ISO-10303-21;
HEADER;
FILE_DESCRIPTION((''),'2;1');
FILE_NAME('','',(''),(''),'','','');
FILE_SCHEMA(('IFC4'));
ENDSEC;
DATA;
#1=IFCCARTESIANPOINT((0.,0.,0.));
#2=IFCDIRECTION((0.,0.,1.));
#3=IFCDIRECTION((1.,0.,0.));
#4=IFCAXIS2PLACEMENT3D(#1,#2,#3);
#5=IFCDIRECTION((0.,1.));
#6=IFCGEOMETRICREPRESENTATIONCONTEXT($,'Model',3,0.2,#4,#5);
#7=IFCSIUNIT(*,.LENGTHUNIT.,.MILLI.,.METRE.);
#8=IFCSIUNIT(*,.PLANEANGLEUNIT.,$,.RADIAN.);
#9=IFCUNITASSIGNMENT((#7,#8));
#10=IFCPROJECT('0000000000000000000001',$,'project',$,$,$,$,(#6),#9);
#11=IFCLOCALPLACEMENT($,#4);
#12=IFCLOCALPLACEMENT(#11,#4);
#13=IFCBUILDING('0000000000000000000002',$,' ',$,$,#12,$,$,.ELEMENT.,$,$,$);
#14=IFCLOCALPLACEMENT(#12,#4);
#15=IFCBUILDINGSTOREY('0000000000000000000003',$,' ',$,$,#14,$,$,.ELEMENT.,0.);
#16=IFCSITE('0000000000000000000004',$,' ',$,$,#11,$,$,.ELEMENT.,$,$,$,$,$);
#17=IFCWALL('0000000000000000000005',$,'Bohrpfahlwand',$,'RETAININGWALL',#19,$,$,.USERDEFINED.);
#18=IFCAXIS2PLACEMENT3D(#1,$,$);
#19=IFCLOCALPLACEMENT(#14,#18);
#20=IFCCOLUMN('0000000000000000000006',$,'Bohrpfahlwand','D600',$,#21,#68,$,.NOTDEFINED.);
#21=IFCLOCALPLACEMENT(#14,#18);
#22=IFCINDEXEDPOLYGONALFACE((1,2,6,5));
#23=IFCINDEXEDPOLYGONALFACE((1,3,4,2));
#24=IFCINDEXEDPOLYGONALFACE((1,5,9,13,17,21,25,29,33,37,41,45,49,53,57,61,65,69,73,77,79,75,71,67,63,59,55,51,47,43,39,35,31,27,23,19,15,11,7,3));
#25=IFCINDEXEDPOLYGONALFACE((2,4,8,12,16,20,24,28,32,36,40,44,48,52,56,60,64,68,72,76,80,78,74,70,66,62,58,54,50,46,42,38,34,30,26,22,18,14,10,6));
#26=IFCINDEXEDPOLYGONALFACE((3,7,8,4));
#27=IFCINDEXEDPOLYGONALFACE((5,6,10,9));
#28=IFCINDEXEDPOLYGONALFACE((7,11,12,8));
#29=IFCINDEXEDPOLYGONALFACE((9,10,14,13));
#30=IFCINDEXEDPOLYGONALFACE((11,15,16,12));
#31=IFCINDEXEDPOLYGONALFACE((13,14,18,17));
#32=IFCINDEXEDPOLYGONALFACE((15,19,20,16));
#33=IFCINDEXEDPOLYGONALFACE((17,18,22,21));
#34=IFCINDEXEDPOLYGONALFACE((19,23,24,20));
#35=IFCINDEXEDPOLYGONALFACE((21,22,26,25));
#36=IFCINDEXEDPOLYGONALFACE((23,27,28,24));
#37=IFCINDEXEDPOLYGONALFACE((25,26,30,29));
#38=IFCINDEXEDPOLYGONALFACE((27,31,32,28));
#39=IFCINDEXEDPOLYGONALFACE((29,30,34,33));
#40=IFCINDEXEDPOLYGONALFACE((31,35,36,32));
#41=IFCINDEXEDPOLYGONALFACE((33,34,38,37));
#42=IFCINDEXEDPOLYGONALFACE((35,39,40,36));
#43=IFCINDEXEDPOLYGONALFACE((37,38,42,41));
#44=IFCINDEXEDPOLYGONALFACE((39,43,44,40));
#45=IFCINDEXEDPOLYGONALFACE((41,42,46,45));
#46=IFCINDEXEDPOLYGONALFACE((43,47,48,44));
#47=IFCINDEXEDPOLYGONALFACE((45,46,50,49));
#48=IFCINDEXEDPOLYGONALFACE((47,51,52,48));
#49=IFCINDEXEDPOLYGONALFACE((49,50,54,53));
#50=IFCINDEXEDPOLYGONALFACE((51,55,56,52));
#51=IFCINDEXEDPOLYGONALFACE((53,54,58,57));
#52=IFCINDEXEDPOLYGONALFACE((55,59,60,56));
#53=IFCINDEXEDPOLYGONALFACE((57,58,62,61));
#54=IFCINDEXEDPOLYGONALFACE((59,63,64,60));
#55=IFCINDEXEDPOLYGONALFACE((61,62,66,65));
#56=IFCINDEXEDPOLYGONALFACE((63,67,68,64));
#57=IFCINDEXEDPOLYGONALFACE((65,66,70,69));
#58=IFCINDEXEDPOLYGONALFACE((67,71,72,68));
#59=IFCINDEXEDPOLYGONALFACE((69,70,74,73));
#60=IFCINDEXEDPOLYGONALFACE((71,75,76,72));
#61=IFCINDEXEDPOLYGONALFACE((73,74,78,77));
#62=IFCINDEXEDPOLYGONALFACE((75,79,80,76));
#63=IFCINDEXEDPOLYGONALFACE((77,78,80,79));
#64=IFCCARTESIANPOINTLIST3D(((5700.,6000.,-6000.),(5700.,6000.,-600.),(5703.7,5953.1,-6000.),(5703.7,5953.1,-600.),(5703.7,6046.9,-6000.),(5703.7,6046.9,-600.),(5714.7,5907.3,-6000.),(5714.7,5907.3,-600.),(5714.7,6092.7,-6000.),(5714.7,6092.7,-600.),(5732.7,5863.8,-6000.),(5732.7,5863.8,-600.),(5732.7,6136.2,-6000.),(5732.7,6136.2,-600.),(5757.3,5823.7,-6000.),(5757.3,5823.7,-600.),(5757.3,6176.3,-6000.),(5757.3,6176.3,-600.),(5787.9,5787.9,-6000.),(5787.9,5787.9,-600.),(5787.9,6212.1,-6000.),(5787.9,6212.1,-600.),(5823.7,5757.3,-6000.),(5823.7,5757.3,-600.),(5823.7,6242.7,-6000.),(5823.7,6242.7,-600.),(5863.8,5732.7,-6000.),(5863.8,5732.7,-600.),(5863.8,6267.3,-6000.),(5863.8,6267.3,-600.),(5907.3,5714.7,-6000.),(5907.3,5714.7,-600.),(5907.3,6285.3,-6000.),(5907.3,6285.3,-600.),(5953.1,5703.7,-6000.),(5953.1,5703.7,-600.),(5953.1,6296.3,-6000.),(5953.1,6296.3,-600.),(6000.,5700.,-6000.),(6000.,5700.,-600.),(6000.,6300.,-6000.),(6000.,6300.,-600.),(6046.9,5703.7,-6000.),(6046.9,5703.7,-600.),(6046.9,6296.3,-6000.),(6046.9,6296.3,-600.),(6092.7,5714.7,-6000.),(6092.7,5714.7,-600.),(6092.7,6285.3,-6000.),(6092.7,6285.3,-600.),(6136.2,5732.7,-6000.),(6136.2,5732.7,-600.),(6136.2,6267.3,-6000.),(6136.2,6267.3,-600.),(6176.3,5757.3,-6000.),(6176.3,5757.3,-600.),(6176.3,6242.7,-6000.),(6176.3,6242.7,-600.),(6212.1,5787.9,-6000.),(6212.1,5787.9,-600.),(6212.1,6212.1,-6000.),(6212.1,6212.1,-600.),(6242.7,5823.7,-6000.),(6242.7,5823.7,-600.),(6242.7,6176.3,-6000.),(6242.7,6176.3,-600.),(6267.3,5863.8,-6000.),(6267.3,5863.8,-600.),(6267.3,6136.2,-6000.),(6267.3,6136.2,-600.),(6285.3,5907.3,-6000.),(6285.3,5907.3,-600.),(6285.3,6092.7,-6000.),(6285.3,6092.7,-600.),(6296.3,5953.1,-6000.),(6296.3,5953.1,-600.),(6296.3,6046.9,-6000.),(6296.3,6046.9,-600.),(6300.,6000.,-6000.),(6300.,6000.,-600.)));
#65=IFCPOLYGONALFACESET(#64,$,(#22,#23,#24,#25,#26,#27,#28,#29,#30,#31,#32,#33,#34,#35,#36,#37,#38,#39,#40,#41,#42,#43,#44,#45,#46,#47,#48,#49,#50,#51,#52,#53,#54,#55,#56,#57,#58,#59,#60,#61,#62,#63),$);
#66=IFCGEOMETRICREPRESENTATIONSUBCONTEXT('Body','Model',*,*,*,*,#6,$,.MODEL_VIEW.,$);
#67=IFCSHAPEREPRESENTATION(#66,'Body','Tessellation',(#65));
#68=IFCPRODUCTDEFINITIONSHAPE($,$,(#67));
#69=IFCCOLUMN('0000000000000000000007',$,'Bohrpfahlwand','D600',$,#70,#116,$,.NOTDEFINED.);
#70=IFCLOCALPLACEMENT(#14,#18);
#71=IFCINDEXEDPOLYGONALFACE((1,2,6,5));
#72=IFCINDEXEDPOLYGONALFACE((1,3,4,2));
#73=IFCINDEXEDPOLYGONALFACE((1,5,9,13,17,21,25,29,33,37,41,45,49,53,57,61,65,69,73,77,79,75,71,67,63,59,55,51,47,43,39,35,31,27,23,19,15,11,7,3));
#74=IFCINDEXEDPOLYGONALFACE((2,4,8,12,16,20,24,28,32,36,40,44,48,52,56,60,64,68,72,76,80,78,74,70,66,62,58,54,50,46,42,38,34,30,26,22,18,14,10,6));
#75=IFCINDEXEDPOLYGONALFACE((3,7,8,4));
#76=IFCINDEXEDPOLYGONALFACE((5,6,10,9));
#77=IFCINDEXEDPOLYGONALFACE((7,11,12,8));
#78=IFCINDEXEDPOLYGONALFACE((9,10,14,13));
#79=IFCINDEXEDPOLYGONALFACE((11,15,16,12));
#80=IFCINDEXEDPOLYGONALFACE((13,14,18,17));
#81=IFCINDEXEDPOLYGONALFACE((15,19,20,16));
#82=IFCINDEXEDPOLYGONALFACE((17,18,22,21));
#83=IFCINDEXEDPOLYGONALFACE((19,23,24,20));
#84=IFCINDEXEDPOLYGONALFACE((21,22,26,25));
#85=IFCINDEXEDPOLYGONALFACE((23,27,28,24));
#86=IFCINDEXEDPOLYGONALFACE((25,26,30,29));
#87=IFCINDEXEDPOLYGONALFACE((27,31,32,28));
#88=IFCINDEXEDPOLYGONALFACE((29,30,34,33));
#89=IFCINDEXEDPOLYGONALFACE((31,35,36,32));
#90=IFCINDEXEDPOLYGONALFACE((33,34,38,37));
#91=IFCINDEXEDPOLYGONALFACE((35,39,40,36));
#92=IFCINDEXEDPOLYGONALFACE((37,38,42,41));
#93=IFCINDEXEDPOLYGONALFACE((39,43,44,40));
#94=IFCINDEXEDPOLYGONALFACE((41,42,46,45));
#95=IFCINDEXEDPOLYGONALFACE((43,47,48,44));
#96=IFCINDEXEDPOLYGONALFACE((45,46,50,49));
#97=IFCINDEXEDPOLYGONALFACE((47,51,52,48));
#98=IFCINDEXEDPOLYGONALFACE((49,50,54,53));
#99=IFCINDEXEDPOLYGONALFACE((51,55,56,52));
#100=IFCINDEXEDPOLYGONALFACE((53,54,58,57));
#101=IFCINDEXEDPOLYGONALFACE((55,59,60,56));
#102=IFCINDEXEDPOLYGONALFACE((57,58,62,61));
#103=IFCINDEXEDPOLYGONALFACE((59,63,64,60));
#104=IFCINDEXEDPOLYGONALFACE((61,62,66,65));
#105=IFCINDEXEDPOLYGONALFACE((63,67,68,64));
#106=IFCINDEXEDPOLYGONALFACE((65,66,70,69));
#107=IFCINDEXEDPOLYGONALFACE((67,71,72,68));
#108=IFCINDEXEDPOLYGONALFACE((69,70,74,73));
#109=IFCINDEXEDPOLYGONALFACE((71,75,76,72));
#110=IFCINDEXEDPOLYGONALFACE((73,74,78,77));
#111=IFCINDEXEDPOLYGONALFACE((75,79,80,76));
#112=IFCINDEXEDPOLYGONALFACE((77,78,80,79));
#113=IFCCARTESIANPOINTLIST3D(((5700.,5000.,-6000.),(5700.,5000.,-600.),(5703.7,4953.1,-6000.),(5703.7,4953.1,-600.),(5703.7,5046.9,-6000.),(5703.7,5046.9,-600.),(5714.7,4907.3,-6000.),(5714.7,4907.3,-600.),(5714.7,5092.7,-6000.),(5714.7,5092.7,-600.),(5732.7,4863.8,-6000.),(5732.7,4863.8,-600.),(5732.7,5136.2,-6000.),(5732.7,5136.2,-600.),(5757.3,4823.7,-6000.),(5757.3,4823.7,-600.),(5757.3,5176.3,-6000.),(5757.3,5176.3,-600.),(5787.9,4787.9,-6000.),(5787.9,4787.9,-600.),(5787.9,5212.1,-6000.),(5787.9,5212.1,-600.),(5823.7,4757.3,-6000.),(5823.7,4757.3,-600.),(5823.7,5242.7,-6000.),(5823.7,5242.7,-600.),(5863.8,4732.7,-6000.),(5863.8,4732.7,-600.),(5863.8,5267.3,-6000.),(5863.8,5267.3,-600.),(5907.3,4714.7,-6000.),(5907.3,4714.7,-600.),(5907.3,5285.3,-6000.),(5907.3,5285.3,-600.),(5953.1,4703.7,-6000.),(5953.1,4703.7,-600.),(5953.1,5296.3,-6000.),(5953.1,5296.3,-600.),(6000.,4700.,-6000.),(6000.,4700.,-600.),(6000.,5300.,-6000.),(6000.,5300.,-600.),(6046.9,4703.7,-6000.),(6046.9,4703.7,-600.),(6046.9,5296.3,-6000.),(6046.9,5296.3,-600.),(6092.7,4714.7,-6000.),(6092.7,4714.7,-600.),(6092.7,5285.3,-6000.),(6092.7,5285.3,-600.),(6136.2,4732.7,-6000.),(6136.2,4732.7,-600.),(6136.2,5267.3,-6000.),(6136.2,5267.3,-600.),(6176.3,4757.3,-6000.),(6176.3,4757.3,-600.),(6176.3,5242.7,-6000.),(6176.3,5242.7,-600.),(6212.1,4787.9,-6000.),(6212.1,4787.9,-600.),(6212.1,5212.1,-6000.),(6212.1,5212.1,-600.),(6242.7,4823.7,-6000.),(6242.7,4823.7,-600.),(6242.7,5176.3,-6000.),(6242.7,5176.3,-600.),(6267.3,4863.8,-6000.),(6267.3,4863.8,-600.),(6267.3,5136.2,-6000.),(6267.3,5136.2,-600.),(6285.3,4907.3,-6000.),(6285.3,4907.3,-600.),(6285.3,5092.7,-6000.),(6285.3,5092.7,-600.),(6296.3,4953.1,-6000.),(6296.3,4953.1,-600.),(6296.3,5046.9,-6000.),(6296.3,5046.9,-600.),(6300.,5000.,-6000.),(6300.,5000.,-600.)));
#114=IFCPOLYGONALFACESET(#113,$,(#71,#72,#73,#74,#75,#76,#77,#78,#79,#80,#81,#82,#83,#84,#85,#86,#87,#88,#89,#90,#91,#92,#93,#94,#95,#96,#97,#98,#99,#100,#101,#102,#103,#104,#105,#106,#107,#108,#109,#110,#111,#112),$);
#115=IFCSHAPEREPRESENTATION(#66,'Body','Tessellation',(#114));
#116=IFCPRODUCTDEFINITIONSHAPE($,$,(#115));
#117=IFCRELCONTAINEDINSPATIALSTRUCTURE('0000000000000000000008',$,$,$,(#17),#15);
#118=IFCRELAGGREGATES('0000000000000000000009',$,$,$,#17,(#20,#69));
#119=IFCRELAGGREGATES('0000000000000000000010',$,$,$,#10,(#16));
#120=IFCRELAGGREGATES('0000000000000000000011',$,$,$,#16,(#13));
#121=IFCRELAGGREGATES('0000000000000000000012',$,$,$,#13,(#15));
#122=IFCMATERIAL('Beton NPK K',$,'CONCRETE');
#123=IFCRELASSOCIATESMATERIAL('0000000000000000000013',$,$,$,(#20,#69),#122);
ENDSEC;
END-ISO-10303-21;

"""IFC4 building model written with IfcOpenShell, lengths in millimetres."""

from ifc_helpers import new_model, si_unit, direction, frame, origin_with_axes, place, context, subcontext, project, spatial, line, indexed_curve, outline, extrude, material, element, aggregate, save


model = new_model("IFC4")

# Units and contexts
model_context = context("Model", 3, precision=0.2, world=origin_with_axes(), true_north=direction((0.0, 1.0)))
body_context = subcontext(model_context, "Body", "Model", "MODEL_VIEW")
ifc_project = project(units=[si_unit("LENGTHUNIT", "METRE", prefix="MILLI"), si_unit("PLANEANGLEUNIT", "RADIAN")], contexts=[model_context])

# Site, building, storey
site_placement = place(None, origin_with_axes())
site = spatial("IfcSite", under=ifc_project, at=site_placement, Name=" ", CompositionType="ELEMENT")
building_placement = place(site_placement, origin_with_axes())
building = spatial("IfcBuilding", under=site, at=building_placement, Name=" ", CompositionType="ELEMENT")
storey_placement = place(building_placement, origin_with_axes())
storey = spatial("IfcBuildingStorey", under=building, at=storey_placement, Name=" ", CompositionType="ELEMENT", Elevation=0.0)

# Wall, columns
wall_1_placement = place(storey_placement, frame((6000.0, 5000.0, -6000.0), z_axis=(-1.0, 0.0, 0.0), x_axis=(0.0, 0.0, 1.0)))
wall_1 = element("IfcWall", 1, at=wall_1_placement, inside=storey, Name="Bohrpfahlwand", ObjectType="RETAININGWALL", PredefinedType="USERDEFINED")
ifc_material_1 = material(Name="Beton NPK K", Category="CONCRETE")
column_1_placement = place(wall_1_placement, frame((0.0, 1000.0, 0.0), z_axis=(0.0, 0.0, 1.0), x_axis=(1.0, 0.0, 0.0)))
column_1 = element("IfcColumn", 2, at=column_1_placement, material=ifc_material_1, Name="Bohrpfahlwand", Description="D600", PredefinedType="NOTDEFINED", context=body_context, shape_type="SolidModel", body=[
    extrude(outline(indexed_curve([(300.0, 0.0), (296.3, 46.9), (285.3, 92.7), (267.3, 136.2), (242.7, 176.3), (212.1, 212.1), (176.3, 242.7), (136.2, 267.3), (92.7, 285.3), (46.9, 296.3), (0.0, 300.0), (-46.9, 296.3), (-92.7, 285.3), (-136.2, 267.3), (-176.3, 242.7), (-212.1, 212.1), (-242.7, 176.3), (-267.3, 136.2), (-285.3, 92.7), (-296.3, 46.9), (-300.0, 0.0), (-296.3, -46.9), (-285.3, -92.7), (-267.3, -136.2), (-242.7, -176.3), (-212.1, -212.1), (-176.3, -242.7), (-136.2, -267.3), (-92.7, -285.3), (-46.9, -296.3), (0.0, -300.0), (46.9, -296.3), (92.7, -285.3), (136.2, -267.3), (176.3, -242.7), (212.1, -212.1), (242.7, -176.3), (267.3, -136.2), (285.3, -92.7), (296.3, -46.9)], segments=[line(1, 2, 3, 4, 5, 6, 7, 8, 9, 10, 11, 12, 13, 14, 15, 16, 17, 18, 19, 20, 21, 22, 23, 24, 25, 26, 27, 28, 29, 30, 31, 32, 33, 34, 35, 36, 37, 38, 39, 40, 1)])), frame((0.0, 0.0, 0.0), z_axis=(-1.0, 0.0, 0.0), x_axis=(0.0, 0.0, 1.0)), (0.0, 0.0, -1.0), 5400.0),
])
column_2_placement = place(wall_1_placement, origin_with_axes())
column_2 = element("IfcColumn", 3, at=column_2_placement, material=ifc_material_1, Name="Bohrpfahlwand", Description="D600", PredefinedType="NOTDEFINED", context=body_context, shape_type="SolidModel", body=[
    extrude(outline(indexed_curve([(300.0, 0.0), (296.3, 46.9), (285.3, 92.7), (267.3, 136.2), (242.7, 176.3), (212.1, 212.1), (176.3, 242.7), (136.2, 267.3), (92.7, 285.3), (46.9, 296.3), (0.0, 300.0), (-46.9, 296.3), (-92.7, 285.3), (-136.2, 267.3), (-176.3, 242.7), (-212.1, 212.1), (-242.7, 176.3), (-267.3, 136.2), (-285.3, 92.7), (-296.3, 46.9), (-300.0, 0.0), (-296.3, -46.9), (-285.3, -92.7), (-267.3, -136.2), (-242.7, -176.3), (-212.1, -212.1), (-176.3, -242.7), (-136.2, -267.3), (-92.7, -285.3), (-46.9, -296.3), (0.0, -300.0), (46.9, -296.3), (92.7, -285.3), (136.2, -267.3), (176.3, -242.7), (212.1, -212.1), (242.7, -176.3), (267.3, -136.2), (285.3, -92.7), (296.3, -46.9)], segments=[line(1, 2, 3, 4, 5, 6, 7, 8, 9, 10, 11, 12, 13, 14, 15, 16, 17, 18, 19, 20, 21, 22, 23, 24, 25, 26, 27, 28, 29, 30, 31, 32, 33, 34, 35, 36, 37, 38, 39, 40, 1)])), frame((0.0, 0.0, 0.0), z_axis=(-1.0, 0.0, 0.0), x_axis=(0.0, 0.0, 1.0)), (0.0, 0.0, -1.0), 5400.0),
])
aggregate(wall_1, [column_1, column_2])

save(model, "model.ifc")
